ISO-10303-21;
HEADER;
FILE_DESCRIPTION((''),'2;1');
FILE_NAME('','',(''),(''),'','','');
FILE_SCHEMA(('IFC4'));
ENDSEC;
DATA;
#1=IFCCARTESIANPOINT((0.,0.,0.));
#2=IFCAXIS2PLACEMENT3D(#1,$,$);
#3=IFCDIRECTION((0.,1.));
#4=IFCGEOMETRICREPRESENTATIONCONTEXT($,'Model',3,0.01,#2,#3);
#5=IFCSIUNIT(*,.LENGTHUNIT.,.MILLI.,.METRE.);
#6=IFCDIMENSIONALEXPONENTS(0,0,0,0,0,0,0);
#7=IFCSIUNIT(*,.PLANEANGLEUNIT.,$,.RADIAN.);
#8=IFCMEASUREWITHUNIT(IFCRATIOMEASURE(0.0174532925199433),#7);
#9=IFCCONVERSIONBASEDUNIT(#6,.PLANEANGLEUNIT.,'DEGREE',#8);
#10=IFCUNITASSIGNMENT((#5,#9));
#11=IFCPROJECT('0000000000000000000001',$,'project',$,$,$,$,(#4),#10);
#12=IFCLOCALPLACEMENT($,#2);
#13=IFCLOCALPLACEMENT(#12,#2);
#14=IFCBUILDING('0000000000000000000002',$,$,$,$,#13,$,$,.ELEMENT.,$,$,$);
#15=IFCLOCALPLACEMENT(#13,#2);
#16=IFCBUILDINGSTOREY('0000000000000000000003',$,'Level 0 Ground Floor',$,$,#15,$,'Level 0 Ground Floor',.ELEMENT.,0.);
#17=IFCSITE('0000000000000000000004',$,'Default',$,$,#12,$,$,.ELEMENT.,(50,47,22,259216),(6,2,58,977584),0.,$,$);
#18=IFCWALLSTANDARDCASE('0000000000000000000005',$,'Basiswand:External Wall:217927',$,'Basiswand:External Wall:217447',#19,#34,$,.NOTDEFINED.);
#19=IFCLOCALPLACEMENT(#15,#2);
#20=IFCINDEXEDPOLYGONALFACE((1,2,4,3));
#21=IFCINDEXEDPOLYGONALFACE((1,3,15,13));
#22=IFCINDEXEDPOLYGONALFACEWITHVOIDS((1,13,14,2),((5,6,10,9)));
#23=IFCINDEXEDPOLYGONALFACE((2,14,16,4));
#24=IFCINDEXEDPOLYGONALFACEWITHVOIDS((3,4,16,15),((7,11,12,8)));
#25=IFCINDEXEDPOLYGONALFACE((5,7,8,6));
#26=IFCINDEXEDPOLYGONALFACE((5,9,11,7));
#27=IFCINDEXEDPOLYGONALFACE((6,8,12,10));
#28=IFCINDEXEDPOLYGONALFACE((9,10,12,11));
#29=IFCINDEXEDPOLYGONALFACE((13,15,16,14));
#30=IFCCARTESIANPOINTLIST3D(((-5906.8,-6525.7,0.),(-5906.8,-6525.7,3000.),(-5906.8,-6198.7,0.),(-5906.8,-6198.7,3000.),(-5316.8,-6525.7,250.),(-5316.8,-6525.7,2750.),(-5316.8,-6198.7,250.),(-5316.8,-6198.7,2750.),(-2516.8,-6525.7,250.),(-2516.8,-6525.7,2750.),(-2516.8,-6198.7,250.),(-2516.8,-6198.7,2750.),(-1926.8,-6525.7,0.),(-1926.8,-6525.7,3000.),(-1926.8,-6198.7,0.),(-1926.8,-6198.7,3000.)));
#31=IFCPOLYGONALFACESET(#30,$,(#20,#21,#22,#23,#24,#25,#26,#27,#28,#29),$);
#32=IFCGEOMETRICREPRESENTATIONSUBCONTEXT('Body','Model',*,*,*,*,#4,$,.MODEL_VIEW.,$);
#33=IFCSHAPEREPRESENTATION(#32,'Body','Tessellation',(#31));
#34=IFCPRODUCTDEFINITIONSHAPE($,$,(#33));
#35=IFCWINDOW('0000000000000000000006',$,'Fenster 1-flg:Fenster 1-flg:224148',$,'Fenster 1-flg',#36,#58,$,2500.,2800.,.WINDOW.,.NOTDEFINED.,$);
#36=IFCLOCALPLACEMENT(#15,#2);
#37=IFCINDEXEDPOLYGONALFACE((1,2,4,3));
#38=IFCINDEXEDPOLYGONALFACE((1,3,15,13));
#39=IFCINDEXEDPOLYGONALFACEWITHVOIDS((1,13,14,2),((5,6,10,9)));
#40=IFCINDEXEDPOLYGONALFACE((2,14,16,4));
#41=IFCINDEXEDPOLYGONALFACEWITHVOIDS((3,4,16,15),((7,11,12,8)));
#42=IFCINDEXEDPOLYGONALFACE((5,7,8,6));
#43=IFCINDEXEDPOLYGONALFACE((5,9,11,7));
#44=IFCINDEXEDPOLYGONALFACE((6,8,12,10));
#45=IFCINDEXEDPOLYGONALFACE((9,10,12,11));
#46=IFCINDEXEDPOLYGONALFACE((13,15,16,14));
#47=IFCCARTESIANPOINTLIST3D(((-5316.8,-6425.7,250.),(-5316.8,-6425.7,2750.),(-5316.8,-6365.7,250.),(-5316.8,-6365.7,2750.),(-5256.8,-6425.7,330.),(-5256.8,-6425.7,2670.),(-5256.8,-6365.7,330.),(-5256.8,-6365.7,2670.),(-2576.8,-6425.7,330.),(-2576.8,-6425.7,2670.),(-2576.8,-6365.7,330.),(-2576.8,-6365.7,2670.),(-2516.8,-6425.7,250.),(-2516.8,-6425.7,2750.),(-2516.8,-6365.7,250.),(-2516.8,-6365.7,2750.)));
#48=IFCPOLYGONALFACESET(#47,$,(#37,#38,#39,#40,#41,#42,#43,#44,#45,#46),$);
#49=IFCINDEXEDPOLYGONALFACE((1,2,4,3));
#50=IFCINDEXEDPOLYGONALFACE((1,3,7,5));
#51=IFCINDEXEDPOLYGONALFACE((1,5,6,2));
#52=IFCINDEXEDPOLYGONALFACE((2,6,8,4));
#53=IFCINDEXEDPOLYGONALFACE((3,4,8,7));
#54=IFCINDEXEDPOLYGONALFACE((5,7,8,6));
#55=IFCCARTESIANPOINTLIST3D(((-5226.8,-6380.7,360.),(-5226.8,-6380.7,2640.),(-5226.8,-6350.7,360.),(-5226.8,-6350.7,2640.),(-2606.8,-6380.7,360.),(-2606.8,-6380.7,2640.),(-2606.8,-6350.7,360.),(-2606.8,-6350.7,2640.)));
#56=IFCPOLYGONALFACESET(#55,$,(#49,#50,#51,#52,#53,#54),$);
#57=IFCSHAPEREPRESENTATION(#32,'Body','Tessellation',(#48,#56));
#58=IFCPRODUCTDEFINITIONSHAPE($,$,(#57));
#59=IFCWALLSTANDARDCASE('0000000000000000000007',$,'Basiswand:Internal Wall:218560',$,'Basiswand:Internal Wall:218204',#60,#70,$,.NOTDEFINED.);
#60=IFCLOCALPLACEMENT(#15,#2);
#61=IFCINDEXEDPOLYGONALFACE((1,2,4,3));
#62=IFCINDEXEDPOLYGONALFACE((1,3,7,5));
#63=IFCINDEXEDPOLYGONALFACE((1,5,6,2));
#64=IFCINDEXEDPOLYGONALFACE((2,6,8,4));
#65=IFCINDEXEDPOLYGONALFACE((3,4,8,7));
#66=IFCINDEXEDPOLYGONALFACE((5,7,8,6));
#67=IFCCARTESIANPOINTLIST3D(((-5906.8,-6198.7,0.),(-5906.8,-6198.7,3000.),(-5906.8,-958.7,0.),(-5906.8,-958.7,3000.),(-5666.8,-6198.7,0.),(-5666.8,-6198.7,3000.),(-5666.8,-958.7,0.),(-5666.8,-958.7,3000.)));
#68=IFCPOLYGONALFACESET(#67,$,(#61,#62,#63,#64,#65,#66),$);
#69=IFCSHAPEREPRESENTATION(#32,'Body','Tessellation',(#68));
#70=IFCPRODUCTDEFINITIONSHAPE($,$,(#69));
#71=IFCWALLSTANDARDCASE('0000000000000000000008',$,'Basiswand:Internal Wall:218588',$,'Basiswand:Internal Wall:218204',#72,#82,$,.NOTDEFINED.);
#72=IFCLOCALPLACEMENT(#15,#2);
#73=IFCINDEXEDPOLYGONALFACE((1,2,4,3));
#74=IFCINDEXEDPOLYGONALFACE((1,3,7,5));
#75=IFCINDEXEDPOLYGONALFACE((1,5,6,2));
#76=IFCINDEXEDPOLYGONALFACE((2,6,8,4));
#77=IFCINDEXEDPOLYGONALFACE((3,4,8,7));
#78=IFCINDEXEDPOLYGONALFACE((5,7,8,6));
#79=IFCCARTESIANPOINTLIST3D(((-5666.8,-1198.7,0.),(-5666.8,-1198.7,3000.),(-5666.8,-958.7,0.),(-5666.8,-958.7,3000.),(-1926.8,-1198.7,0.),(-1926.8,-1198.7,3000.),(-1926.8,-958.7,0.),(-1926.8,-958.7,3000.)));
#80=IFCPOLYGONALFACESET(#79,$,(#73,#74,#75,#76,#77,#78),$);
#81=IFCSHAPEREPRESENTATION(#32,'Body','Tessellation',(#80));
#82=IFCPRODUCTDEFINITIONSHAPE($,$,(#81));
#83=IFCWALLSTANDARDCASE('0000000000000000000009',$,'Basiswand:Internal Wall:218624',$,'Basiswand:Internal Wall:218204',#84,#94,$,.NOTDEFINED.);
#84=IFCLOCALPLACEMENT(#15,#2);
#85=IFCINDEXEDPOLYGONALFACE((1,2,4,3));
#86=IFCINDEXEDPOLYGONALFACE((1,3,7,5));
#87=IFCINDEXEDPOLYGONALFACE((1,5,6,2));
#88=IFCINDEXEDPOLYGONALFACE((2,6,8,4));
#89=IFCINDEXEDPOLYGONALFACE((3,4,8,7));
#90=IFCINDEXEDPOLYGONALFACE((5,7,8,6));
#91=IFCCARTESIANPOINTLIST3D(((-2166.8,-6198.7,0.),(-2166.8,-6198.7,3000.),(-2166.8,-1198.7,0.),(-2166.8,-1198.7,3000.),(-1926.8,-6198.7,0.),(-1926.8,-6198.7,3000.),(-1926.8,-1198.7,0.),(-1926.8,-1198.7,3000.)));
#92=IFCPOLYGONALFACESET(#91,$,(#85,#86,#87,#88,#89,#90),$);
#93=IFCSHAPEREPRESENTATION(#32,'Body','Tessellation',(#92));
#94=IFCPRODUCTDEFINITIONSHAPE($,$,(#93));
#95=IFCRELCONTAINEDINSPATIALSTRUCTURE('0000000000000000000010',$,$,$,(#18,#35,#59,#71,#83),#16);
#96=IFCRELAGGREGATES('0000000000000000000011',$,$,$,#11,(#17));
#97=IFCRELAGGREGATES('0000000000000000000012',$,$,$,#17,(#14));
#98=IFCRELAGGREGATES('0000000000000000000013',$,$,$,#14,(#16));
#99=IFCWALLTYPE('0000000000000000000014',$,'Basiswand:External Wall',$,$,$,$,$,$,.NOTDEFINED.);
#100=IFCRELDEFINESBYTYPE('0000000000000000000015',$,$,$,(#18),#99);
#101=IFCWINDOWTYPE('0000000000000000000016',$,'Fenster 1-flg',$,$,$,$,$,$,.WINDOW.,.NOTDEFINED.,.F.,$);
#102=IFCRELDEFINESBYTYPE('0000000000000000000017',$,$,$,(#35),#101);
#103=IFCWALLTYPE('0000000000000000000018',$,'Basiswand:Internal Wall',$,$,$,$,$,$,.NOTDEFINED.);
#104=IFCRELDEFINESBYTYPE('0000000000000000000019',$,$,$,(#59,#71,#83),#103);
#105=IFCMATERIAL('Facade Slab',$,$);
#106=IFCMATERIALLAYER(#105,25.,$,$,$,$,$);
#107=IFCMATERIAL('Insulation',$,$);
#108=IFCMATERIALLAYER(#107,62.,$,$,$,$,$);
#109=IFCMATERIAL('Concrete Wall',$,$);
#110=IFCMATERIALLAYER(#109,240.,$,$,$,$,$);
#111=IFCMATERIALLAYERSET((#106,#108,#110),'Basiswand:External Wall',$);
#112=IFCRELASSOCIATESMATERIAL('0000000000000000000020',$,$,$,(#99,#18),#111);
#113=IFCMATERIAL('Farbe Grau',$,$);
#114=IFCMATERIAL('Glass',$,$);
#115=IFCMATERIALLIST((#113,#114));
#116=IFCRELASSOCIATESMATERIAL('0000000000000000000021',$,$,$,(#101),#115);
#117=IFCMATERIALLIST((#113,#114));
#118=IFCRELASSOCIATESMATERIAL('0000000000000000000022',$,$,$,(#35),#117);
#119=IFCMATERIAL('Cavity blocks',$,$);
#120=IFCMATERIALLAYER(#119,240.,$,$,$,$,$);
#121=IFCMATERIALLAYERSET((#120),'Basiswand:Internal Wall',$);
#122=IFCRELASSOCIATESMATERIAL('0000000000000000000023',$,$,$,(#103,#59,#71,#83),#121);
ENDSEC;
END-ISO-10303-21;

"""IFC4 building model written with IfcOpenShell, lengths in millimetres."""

from ifc_helpers import new_model, entity, si_unit, converted_unit, direction, frame, frame_2d, origin, origin_2d_with_axis, place, context, subcontext, project, spatial, polyline, rectangle, outline, extrude, clip, bounded_halfspace, source, transform, mapped, material, material_list, layer, layer_set, layer_usage, type_object, type_shapes, element, fill, save


model = new_model("IFC4")

# Units and contexts
model_context = context("Model", 3, precision=0.01, world=origin(), true_north=direction((0.0, 1.0)))
body_context = subcontext(model_context, "Body", "Model", "MODEL_VIEW")
ifc_project = project(units=[si_unit("LENGTHUNIT", "METRE", prefix="MILLI"), converted_unit("PLANEANGLEUNIT", "DEGREE", entity("IfcRatioMeasure", 0.0174532925199433), si_unit("PLANEANGLEUNIT", "RADIAN"), dimensions=[0, 0, 0, 0, 0, 0, 0])], contexts=[model_context])

# Site, building, storey
site_placement = place(None, origin())
site = spatial("IfcSite", under=ifc_project, at=site_placement, Name="Default", CompositionType="ELEMENT", RefLatitude=(50, 47, 22, 259216), RefLongitude=(6, 2, 58, 977584), RefElevation=0.0)
building_placement = place(site_placement, origin())
building = spatial("IfcBuilding", under=site, at=building_placement, CompositionType="ELEMENT")
storey_placement = place(building_placement, origin())
storey = spatial("IfcBuildingStorey", under=building, at=storey_placement, Name="Level 0 Ground Floor", LongName="Level 0 Ground Floor", CompositionType="ELEMENT", Elevation=0.0)

# Wall, opening, window
ifc_material_1 = material(Name="Facade Slab")
ifc_layer_1 = layer(ifc_material_1, 25.0)
ifc_material_2 = material(Name="Insulation")
ifc_layer_2 = layer(ifc_material_2, 62.0)
ifc_material_3 = material(Name="Concrete Wall")
ifc_layer_3 = layer(ifc_material_3, 240.0)
ifc_layer_set_1 = layer_set([ifc_layer_1, ifc_layer_2, ifc_layer_3], Name="Basiswand:External Wall")
ifc_layer_usage_1 = layer_usage(ifc_layer_set_1, "AXIS2", "POSITIVE", -163.5)
wall_type_1 = type_object("IfcWallType", Name="Basiswand:External Wall", PredefinedType="NOTDEFINED", material=ifc_layer_set_1)
wall_1_placement = place(storey_placement, frame((-5906.8, -6362.2, 0.0)))
wall_1 = element("IfcWallStandardCase", 1, at=wall_1_placement, inside=storey, type_object=wall_type_1, material=ifc_layer_usage_1, Name="Basiswand:External Wall:217927", ObjectType="Basiswand:External Wall:217447", PredefinedType="NOTDEFINED", context=body_context, shape_type="Clipping", body=[
    clip(extrude(rectangle(XDim=3980.0, YDim=327.0, at=frame_2d((1990.0, 0.0), x_axis=(-1.0, 0.0))), origin(), (0.0, 0.0, 1.0), 3000.0), bounded_halfspace(frame((0.0, -163.5, 3000.0), z_axis=(0.0, 0.0, -1.0), x_axis=(0.0, -1.0, 0.0)), True, frame((0.0, -163.5, 3000.0)), polyline([(0.0, 0.0), (3980.0, 0.0), (3980.0, 327.0), (3740.0, 327.0), (240.0, 327.0), (0.0, 327.0), (0.0, 0.0)]))),
])
opening_placement = place(wall_1_placement, frame((590.0, -163.5, 250.0)))
opening = element("IfcOpeningElement", 2, at=opening_placement, cuts=wall_1, ObjectType="Opening", PredefinedType="OPENING", context=body_context, shape_type="SweptSolid", body=[
    extrude(rectangle(XDim=2500.0, YDim=2800.0, at=frame_2d((1250.0, 1400.0), x_axis=(1.0, 0.0))), frame((0.0, 0.0, 0.0), z_axis=(0.0, 1.0, 0.0), x_axis=(0.0, 0.0, 1.0)), (0.0, 0.0, 1.0), 327.0),
])
ifc_material_4 = material(Name="Farbe Grau")
ifc_material_5 = material(Name="Glass")
ifc_material_list_1 = material_list([ifc_material_4, ifc_material_5])
ifc_material_list_2 = material_list([ifc_material_4, ifc_material_5])
window_type = type_object("IfcWindowType", Name="Fenster 1-flg", ParameterTakesPrecedence=False, PartitioningType="NOTDEFINED", PredefinedType="WINDOW", material=ifc_material_list_2)
shared_shape_1 = source(origin(), body_context, "Body", "SweptSolid", [
    extrude(outline(polyline([(-1250.0, -1400.0), (1250.0, -1400.0), (1250.0, 1400.0), (-1250.0, 1400.0), (-1250.0, -1400.0)]), holes=[polyline([(-1170.0, -1340.0), (-1170.0, 1340.0), (1170.0, 1340.0), (1170.0, -1340.0), (-1170.0, -1340.0)])]), frame((1400.0, 167.0, 1250.0), z_axis=(0.0, 1.0, 0.0), x_axis=(0.0, 0.0, -1.0)), (0.0, 0.0, 1.0), 60.0),
    extrude(rectangle(XDim=30.0, YDim=2620.0, at=origin_2d_with_axis()), frame((1400.0, 167.0, 110.0), z_axis=(0.0, 0.0, 1.0), x_axis=(0.0, 1.0, 0.0)), (0.0, 0.0, 1.0), 2280.0),
])
type_shapes(window_type, [shared_shape_1])
window_placement = place(opening_placement, frame((2800.0, 327.0, 0.0), z_axis=(0.0, 0.0, 1.0), x_axis=(-1.0, 0.0, 0.0)))
window = element("IfcWindow", 3, at=window_placement, inside=storey, type_object=window_type, material=ifc_material_list_1, Name="Fenster 1-flg:Fenster 1-flg:224148", ObjectType="Fenster 1-flg", OverallHeight=2500.0, OverallWidth=2800.0, PartitioningType="NOTDEFINED", PredefinedType="WINDOW", context=body_context, shape_type="MappedRepresentation", body=[
    mapped(shared_shape_1, transform((0.0, 0.0, 0.0), scale=1.0)),
])
fill(opening, window)

# Walls
ifc_material_6 = material(Name="Cavity blocks")
ifc_layer_4 = layer(ifc_material_6, 240.0)
ifc_layer_set_2 = layer_set([ifc_layer_4], Name="Basiswand:Internal Wall")
ifc_layer_usage_2 = layer_usage(ifc_layer_set_2, "AXIS2", "NEGATIVE", 120.0)
wall_type_2 = type_object("IfcWallType", Name="Basiswand:Internal Wall", PredefinedType="NOTDEFINED", material=ifc_layer_set_2)
wall_2_placement = place(storey_placement, frame((-5786.8, -6198.7, 0.0), z_axis=(0.0, 0.0, 1.0), x_axis=(0.0, 1.0, 0.0)))
element("IfcWallStandardCase", 4, at=wall_2_placement, inside=storey, type_object=wall_type_2, material=ifc_layer_usage_2, Name="Basiswand:Internal Wall:218560", ObjectType="Basiswand:Internal Wall:218204", PredefinedType="NOTDEFINED", context=body_context, shape_type="Clipping", body=[
    clip(extrude(rectangle(XDim=5240.0, YDim=240.0, at=frame_2d((2620.0, 0.0), x_axis=(-1.0, 0.0))), origin(), (0.0, 0.0, 1.0), 3000.0), bounded_halfspace(frame((0.0, -120.0, 3000.0), z_axis=(0.0, 0.0, -1.0), x_axis=(-1.0, 0.0, 0.0)), True, frame((0.0, -120.0, 3000.0)), polyline([(0.0, 0.0), (5000.0, 0.0), (5240.0, 0.0), (5240.0, 240.0), (0.0, 240.0), (0.0, 0.0)]))),
])
ifc_layer_usage_3 = layer_usage(ifc_layer_set_2, "AXIS2", "NEGATIVE", 120.0)
wall_3_placement = place(storey_placement, frame((-5666.8, -1078.7, 0.0)))
element("IfcWallStandardCase", 5, at=wall_3_placement, inside=storey, type_object=wall_type_2, material=ifc_layer_usage_3, Name="Basiswand:Internal Wall:218588", ObjectType="Basiswand:Internal Wall:218204", PredefinedType="NOTDEFINED", context=body_context, shape_type="Clipping", body=[
    clip(extrude(rectangle(XDim=3740.0, YDim=240.0, at=frame_2d((1870.0, 0.0), x_axis=(-1.0, 0.0))), origin(), (0.0, 0.0, 1.0), 3000.0), bounded_halfspace(frame((0.0, -120.0, 3000.0), z_axis=(0.0, 0.0, -1.0), x_axis=(0.0, -1.0, 0.0)), True, frame((0.0, -120.0, 3000.0)), polyline([(0.0, 0.0), (3500.0, 0.0), (3740.0, 0.0), (3740.0, 240.0), (0.0, 240.0), (0.0, 0.0)]))),
])
ifc_layer_usage_4 = layer_usage(ifc_layer_set_2, "AXIS2", "NEGATIVE", 120.0)
wall_4_placement = place(storey_placement, frame((-2046.8, -1198.7, 0.0), z_axis=(0.0, 0.0, 1.0), x_axis=(0.0, -1.0, 0.0)))
element("IfcWallStandardCase", 6, at=wall_4_placement, inside=storey, type_object=wall_type_2, material=ifc_layer_usage_4, Name="Basiswand:Internal Wall:218624", ObjectType="Basiswand:Internal Wall:218204", PredefinedType="NOTDEFINED", context=body_context, shape_type="Clipping", body=[
    clip(extrude(rectangle(XDim=5000.0, YDim=240.0, at=frame_2d((2500.0, 0.0), x_axis=(-1.0, 0.0))), origin(), (0.0, 0.0, 1.0), 3000.0), bounded_halfspace(frame((0.0, -120.0, 3000.0), z_axis=(0.0, 0.0, -1.0), x_axis=(1.0, 0.0, 0.0)), True, frame((0.0, -120.0, 3000.0)), polyline([(0.0, 0.0), (5000.0, 0.0), (5000.0, 240.0), (0.0, 240.0), (0.0, 0.0)]))),
])

save(model, "model.ifc")
